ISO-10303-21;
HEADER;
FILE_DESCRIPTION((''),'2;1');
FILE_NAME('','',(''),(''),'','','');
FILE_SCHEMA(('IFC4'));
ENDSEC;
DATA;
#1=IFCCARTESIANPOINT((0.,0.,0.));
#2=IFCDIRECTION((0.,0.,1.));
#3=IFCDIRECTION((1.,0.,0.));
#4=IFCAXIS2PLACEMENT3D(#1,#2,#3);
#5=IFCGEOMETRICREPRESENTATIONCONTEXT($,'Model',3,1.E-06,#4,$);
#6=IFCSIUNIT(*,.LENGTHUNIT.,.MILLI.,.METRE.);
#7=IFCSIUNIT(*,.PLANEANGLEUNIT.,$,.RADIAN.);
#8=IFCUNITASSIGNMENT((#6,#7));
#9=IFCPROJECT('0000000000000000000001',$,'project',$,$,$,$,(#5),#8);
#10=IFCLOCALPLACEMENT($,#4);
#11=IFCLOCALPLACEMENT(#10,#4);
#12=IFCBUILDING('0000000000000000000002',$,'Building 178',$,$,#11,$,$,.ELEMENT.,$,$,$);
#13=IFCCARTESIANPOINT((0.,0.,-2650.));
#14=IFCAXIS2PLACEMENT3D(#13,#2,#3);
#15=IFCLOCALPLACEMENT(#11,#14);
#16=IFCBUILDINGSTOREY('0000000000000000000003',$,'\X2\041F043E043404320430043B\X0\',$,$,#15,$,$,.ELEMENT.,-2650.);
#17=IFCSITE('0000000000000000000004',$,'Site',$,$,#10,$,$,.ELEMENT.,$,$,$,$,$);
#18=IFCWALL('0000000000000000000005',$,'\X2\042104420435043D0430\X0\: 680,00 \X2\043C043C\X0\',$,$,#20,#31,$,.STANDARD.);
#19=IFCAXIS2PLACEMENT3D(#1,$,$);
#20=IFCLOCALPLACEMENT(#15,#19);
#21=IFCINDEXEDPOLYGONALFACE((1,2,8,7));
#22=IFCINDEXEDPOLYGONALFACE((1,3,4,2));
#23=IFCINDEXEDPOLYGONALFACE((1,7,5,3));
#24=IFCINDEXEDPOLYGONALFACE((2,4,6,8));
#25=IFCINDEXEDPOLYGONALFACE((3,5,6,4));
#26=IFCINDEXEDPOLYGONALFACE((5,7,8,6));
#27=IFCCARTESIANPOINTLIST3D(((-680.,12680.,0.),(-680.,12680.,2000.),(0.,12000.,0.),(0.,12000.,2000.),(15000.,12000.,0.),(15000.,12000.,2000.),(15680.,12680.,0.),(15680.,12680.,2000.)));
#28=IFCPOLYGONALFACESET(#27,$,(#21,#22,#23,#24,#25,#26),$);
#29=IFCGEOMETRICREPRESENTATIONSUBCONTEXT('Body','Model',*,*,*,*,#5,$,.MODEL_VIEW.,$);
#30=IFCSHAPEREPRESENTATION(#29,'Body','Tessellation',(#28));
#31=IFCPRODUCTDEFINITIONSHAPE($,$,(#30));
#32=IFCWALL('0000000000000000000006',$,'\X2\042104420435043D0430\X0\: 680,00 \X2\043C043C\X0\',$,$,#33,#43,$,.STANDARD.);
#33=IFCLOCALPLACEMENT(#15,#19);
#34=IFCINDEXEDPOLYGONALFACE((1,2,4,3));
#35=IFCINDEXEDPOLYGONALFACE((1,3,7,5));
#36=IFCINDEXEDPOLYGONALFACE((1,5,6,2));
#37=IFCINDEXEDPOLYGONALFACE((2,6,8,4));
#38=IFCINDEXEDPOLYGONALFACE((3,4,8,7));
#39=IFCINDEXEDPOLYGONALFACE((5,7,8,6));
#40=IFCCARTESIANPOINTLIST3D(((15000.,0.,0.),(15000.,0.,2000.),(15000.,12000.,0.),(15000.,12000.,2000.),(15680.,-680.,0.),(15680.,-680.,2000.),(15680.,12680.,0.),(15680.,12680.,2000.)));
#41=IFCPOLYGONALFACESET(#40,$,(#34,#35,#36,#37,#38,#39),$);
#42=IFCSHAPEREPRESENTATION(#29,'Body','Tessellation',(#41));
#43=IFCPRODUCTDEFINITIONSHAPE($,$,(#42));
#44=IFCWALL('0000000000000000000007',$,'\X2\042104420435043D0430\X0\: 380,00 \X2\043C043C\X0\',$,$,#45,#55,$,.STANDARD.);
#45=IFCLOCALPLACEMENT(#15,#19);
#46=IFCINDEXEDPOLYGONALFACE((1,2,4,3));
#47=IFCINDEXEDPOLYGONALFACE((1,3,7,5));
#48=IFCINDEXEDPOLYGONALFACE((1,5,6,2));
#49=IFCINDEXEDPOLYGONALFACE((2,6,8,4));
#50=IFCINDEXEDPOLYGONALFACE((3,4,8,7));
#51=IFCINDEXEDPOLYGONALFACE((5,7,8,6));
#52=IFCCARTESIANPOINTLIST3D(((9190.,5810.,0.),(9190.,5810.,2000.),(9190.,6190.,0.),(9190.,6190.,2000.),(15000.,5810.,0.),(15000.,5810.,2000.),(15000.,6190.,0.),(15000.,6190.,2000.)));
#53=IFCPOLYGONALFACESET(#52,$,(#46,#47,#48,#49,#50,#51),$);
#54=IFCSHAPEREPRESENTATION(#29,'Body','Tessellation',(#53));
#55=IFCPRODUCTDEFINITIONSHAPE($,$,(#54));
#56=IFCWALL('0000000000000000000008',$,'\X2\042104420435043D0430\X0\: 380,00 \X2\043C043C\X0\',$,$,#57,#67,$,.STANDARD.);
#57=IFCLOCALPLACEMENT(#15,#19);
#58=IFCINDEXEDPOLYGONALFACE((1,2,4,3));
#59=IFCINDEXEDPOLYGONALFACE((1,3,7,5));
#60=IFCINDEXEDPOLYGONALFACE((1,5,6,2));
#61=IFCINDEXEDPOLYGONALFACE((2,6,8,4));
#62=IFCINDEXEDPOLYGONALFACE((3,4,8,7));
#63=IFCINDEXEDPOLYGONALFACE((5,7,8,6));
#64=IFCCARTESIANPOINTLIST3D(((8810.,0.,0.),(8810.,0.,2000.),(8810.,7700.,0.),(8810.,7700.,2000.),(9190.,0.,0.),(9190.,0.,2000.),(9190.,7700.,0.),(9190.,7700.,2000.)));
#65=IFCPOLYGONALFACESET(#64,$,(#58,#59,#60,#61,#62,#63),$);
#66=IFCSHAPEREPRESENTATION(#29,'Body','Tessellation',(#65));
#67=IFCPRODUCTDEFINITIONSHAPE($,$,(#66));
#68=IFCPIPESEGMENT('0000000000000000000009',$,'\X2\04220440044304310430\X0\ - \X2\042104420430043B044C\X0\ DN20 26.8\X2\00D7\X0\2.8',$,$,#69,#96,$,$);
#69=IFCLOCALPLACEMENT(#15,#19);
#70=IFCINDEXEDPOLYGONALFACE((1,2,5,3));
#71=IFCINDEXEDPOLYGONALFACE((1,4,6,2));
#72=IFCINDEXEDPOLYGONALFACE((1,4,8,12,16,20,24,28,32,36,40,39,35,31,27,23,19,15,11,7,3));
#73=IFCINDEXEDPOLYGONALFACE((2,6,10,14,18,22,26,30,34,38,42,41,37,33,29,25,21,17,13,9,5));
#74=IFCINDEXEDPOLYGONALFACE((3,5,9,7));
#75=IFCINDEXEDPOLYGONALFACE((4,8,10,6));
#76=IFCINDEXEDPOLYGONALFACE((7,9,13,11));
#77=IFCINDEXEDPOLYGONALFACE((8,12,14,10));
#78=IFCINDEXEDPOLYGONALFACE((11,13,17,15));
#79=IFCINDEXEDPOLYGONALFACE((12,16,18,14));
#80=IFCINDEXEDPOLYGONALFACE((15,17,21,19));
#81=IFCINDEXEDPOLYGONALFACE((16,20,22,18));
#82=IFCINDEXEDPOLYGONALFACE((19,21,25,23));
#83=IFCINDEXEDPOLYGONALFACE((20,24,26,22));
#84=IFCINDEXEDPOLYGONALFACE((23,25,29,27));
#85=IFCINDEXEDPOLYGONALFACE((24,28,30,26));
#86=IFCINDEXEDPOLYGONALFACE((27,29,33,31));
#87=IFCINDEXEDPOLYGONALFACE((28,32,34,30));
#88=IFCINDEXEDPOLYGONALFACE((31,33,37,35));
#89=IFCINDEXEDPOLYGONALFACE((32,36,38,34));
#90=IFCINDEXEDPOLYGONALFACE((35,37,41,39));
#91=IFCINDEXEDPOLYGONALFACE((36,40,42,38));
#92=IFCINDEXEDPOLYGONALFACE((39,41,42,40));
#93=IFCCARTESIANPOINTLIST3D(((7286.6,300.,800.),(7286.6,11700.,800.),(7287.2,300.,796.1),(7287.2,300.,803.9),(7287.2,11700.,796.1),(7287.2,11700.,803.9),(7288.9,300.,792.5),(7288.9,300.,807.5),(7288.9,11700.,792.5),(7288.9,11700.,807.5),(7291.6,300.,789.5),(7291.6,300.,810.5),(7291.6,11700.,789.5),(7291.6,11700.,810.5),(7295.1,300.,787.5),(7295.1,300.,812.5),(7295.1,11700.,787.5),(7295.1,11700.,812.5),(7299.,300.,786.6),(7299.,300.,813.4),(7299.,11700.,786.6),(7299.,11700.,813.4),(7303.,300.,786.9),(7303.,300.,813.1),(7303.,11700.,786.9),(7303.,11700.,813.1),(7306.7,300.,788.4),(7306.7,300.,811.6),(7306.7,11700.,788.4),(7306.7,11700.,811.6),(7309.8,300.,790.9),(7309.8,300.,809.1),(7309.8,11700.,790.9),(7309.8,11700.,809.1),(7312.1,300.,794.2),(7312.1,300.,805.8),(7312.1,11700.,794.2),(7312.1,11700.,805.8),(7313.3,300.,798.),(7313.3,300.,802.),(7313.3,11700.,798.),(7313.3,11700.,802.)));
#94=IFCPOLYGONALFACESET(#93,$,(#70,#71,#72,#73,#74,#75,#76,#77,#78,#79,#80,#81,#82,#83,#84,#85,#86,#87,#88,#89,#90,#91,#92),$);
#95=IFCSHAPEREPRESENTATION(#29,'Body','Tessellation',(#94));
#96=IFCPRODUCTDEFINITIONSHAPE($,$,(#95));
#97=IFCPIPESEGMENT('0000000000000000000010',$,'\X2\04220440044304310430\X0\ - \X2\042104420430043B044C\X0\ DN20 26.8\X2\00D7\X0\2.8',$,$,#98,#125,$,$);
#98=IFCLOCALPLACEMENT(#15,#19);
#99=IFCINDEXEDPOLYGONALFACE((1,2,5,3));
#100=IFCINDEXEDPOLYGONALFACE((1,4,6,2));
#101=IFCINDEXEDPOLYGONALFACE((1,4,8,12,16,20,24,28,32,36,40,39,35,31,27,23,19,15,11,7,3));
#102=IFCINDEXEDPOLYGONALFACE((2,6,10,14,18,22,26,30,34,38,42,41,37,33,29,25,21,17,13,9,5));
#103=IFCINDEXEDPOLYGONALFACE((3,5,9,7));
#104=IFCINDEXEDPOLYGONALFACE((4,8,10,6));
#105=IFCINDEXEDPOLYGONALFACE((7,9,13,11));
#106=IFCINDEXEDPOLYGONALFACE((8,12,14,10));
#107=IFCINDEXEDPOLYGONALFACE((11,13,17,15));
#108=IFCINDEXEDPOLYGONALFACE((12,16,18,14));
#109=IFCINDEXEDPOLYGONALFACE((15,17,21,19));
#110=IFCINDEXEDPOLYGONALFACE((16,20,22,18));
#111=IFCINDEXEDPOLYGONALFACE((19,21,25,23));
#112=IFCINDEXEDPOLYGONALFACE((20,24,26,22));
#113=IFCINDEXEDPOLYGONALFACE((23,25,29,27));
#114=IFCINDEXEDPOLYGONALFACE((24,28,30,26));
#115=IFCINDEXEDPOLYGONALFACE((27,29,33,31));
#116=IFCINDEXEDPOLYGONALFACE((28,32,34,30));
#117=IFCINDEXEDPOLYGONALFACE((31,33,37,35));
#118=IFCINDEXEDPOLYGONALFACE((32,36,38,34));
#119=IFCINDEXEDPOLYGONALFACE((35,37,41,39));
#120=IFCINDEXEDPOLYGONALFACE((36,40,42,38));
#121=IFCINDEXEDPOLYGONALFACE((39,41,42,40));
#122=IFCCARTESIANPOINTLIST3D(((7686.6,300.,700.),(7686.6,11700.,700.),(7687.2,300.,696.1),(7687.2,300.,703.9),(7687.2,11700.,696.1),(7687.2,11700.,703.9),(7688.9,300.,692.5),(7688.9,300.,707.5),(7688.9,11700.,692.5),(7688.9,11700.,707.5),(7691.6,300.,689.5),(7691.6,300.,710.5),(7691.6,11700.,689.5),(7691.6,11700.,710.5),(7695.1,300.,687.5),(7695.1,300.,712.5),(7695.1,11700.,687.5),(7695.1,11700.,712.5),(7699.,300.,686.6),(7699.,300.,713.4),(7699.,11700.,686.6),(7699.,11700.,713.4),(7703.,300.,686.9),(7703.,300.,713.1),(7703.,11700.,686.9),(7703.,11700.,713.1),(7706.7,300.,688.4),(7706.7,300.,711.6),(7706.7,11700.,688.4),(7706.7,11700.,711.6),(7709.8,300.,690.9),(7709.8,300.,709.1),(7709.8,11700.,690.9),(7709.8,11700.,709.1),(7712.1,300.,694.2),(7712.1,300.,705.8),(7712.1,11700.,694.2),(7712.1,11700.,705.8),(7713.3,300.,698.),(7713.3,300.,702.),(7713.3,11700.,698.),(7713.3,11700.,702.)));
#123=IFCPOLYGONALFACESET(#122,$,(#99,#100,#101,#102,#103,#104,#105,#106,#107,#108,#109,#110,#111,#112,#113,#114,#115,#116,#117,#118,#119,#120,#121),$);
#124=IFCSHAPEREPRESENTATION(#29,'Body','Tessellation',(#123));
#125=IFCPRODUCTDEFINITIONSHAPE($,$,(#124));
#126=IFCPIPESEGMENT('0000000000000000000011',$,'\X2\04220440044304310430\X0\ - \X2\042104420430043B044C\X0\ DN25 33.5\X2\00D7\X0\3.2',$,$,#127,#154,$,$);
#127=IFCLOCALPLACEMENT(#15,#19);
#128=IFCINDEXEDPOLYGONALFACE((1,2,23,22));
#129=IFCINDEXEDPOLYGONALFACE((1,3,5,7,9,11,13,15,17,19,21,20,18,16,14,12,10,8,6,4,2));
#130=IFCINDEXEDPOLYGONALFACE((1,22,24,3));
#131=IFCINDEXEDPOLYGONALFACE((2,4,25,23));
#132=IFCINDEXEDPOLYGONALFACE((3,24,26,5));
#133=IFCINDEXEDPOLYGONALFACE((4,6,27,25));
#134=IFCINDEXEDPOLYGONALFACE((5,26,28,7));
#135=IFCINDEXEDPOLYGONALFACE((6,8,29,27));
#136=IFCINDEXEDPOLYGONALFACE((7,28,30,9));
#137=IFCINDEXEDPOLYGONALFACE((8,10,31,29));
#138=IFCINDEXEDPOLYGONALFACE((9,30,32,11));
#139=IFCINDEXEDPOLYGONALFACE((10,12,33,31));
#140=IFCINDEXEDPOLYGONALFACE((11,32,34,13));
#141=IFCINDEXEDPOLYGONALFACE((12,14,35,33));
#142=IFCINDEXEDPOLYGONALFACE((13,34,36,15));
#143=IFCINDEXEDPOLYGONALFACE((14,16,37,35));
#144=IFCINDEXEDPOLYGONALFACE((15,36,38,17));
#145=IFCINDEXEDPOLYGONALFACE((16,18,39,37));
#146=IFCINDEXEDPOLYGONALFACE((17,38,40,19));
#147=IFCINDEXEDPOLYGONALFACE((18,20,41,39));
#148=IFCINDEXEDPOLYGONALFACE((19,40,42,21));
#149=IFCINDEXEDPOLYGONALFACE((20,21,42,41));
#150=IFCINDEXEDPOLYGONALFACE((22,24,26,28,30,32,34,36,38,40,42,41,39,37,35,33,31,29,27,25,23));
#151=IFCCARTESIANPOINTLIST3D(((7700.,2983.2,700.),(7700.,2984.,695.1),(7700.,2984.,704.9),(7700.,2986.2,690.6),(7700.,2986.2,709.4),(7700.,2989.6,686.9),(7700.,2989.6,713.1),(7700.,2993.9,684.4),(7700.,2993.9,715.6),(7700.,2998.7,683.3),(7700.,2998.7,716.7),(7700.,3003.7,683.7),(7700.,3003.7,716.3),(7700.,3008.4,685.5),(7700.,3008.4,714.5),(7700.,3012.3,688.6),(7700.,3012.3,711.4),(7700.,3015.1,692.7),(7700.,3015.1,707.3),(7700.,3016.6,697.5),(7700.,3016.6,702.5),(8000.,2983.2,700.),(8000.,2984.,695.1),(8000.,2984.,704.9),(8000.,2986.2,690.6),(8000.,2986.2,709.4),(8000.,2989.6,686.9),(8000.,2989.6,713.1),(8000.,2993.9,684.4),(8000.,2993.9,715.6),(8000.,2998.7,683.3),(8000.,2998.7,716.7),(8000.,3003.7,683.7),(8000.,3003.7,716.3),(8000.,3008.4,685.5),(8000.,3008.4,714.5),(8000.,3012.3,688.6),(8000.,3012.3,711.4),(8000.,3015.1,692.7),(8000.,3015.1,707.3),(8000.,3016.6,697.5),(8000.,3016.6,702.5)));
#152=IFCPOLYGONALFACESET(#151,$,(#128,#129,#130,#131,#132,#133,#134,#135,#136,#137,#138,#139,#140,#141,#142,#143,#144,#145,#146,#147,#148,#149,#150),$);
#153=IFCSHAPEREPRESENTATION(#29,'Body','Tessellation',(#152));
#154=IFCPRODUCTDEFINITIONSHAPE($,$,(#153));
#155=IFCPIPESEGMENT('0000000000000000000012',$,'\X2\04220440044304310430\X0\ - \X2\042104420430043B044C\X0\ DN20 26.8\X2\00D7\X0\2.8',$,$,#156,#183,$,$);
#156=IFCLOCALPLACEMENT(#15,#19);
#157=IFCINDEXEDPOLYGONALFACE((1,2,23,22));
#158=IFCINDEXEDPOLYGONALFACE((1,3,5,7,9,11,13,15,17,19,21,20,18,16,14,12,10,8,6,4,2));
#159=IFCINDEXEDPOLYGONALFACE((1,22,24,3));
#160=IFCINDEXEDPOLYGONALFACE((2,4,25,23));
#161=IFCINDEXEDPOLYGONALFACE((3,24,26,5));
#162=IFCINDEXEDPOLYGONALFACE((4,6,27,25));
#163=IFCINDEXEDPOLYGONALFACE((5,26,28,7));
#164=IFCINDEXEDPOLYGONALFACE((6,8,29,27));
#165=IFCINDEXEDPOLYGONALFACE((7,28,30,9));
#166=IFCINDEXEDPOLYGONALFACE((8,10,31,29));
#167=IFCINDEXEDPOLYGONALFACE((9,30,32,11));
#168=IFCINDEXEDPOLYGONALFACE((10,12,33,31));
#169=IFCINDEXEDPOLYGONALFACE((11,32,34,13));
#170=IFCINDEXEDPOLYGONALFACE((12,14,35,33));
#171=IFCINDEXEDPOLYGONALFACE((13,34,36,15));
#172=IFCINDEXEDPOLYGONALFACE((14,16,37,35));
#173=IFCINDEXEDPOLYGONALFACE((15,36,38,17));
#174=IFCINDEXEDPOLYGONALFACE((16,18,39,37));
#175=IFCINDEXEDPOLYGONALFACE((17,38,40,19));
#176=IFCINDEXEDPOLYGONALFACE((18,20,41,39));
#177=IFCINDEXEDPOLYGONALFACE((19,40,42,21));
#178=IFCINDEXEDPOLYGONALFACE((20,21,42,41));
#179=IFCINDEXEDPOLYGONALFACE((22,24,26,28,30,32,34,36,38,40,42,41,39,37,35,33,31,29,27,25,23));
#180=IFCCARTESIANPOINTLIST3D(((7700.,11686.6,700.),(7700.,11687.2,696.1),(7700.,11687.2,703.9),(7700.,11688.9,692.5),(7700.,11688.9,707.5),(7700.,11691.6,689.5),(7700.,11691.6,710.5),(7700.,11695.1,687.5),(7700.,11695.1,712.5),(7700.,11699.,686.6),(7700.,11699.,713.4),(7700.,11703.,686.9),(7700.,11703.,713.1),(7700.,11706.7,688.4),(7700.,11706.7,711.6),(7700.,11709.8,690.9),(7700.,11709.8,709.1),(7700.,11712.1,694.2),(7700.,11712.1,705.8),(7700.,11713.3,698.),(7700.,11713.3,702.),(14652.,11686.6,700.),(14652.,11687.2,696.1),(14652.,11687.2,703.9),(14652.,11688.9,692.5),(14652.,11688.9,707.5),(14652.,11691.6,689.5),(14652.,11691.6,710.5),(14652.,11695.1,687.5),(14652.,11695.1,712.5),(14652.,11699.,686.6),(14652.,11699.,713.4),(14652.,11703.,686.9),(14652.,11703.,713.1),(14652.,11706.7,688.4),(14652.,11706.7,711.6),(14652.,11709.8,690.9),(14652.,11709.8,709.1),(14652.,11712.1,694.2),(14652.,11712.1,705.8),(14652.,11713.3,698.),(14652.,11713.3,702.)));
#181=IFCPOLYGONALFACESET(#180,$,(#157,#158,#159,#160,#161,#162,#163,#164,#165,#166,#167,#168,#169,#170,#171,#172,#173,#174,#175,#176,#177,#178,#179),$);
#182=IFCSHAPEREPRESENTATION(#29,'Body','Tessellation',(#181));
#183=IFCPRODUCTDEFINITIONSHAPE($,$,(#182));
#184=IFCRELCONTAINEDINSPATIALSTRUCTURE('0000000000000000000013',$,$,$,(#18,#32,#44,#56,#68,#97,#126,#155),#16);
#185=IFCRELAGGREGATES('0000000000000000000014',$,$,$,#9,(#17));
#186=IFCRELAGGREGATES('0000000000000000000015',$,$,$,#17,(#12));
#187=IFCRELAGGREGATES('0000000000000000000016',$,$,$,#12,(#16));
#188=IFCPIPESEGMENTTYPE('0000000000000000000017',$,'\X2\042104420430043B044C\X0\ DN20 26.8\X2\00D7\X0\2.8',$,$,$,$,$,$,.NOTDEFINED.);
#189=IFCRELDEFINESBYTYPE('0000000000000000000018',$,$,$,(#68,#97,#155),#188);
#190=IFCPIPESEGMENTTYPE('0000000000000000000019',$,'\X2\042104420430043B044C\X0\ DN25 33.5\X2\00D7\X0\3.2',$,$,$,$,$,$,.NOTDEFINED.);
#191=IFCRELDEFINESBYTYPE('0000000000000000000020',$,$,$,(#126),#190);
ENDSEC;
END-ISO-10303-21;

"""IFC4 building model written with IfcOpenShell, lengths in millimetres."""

from ifc_helpers import new_model, entity, si_unit, frame, origin_with_axes, place, context, subcontext, project, spatial, line, indexed_curve, outline, extrude, source, transform, mapped, type_object, element, save


model = new_model("IFC4")

# Units and contexts
model_context = context("Model", 3, precision=1e-06, world=origin_with_axes())
body_context = subcontext(model_context, "Body", "Model", "MODEL_VIEW")
ifc_project = project(units=[si_unit("LENGTHUNIT", "METRE", prefix="MILLI"), si_unit("PLANEANGLEUNIT", "RADIAN")], contexts=[model_context])

# Site, building, storey
site_placement = place(None, origin_with_axes())
site = spatial("IfcSite", under=ifc_project, at=site_placement, Name="Site", CompositionType="ELEMENT")
building_placement = place(site_placement, origin_with_axes())
building = spatial("IfcBuilding", under=site, at=building_placement, Name="Building 178", CompositionType="ELEMENT")
storey_placement = place(building_placement, frame((0.0, 0.0, -2650.0), z_axis=(0.0, 0.0, 1.0), x_axis=(1.0, 0.0, 0.0)))
storey = spatial("IfcBuildingStorey", under=building, at=storey_placement, Name="Подвал", CompositionType="ELEMENT", Elevation=-2650.0)

# Walls
shared_shape_1 = source(origin_with_axes(), body_context, "Body", "SweptSolid", [
    extrude(outline(indexed_curve([(-340.0, -340.0), (16020.0, -340.0), (15340.0, 340.0), (340.0, 340.0)], segments=[line(1, 2), line(2, 3), line(3, 4), line(4, 1)])), origin_with_axes(), (0.0, 0.0, 1.0), 2000.0),
])
wall_1_placement = place(storey_placement, frame((15340.0, 12340.0, 0.0), z_axis=(0.0, 0.0, 1.0), x_axis=(-1.0, 0.0, 0.0)))
element("IfcWall", 1, at=wall_1_placement, inside=storey, Name="Стена: 680,00 мм", PredefinedType="STANDARD", context=body_context, shape_type="MappedRepresentation", body=[
    mapped(shared_shape_1, transform((0.0, 0.0, 0.0), x_axis=(1.0, 0.0, 0.0), y_axis=(0.0, 1.0, 0.0), z_axis=(0.0, 0.0, 1.0), scale=1.0)),
])
shared_shape_2 = source(origin_with_axes(), body_context, "Body", "SweptSolid", [
    extrude(outline(indexed_curve([(-340.0, -340.0), (13020.0, -340.0), (12340.0, 340.0), (340.0, 340.0)], segments=[line(1, 2), line(2, 3), line(3, 4), line(4, 1)])), origin_with_axes(), (0.0, 0.0, 1.0), 2000.0),
])
wall_2_placement = place(storey_placement, frame((15340.0, -340.0, 0.0), z_axis=(0.0, 0.0, 1.0), x_axis=(0.0, 1.0, 0.0)))
element("IfcWall", 2, at=wall_2_placement, inside=storey, Name="Стена: 680,00 мм", PredefinedType="STANDARD", context=body_context, shape_type="MappedRepresentation", body=[
    mapped(shared_shape_2, transform((0.0, 0.0, 0.0), x_axis=(1.0, 0.0, 0.0), y_axis=(0.0, 1.0, 0.0), z_axis=(0.0, 0.0, 1.0), scale=1.0)),
])
shared_shape_3 = source(origin_with_axes(), body_context, "Body", "SweptSolid", [
    extrude(outline(indexed_curve([(190.0, -190.0), (6000.0, -190.0), (6000.0, 190.0), (190.0, 190.0)], segments=[line(1, 2), line(2, 3), line(3, 4), line(4, 1)])), origin_with_axes(), (0.0, 0.0, 1.0), 2000.0),
])
wall_3_placement = place(storey_placement, frame((9000.0, 6000.0, 0.0), z_axis=(0.0, 0.0, 1.0), x_axis=(1.0, 0.0, 0.0)))
element("IfcWall", 3, at=wall_3_placement, inside=storey, Name="Стена: 380,00 мм", PredefinedType="STANDARD", context=body_context, shape_type="MappedRepresentation", body=[
    mapped(shared_shape_3, transform((0.0, 0.0, 0.0), x_axis=(1.0, 0.0, 0.0), y_axis=(0.0, 1.0, 0.0), z_axis=(0.0, 0.0, 1.0), scale=1.0)),
])
shared_shape_4 = source(origin_with_axes(), body_context, "Body", "SweptSolid", [
    extrude(outline(indexed_curve([(0.0, -190.0), (7700.0, -190.0), (7700.0, 190.0), (0.0, 190.0)], segments=[line(1, 2), line(2, 3), line(3, 4), line(4, 1)])), origin_with_axes(), (0.0, 0.0, 1.0), 2000.0),
])
wall_4_placement = place(storey_placement, frame((9000.0, 0.0, 0.0), z_axis=(0.0, 0.0, 1.0), x_axis=(0.0, 1.0, 0.0)))
element("IfcWall", 4, at=wall_4_placement, inside=storey, Name="Стена: 380,00 мм", PredefinedType="STANDARD", context=body_context, shape_type="MappedRepresentation", body=[
    mapped(shared_shape_4, transform((0.0, 0.0, 0.0), x_axis=(1.0, 0.0, 0.0), y_axis=(0.0, 1.0, 0.0), z_axis=(0.0, 0.0, 1.0), scale=1.0)),
])

# Pipe segments
pipe_segment_type_1 = type_object("IfcPipeSegmentType", Name="Сталь DN20 26.8×2.8", PredefinedType="NOTDEFINED")
shared_shape_5 = source(origin_with_axes(), body_context, "Body", "AdvancedSweptSolid", [
    entity("IfcSweptDiskSolid", entity("IfcIndexedPolyCurve", entity("IfcCartesianPointList3D", [[0.0, 0.0, 0.0], [0.0, 0.0, -11400.0]]), [entity("IfcLineIndex", [1, 2])]), 13.4),
])
for number, where, z_axis, x_axis, name in (
    (5, (7300.0, 300.0, 800.0), (0.0, -1.0, 0.0), (1.0, 0.0, 0.0), "Труба - Сталь DN20 26.8×2.8"),
    (6, (7700.0, 300.0, 700.0), (0.0, -1.0, 0.0), (1.0, 0.0, 0.0), "Труба - Сталь DN20 26.8×2.8"),
):
    element("IfcPipeSegment", number, at=place(storey_placement, frame(where, z_axis=z_axis, x_axis=x_axis)), inside=storey, type_object=pipe_segment_type_1, Name=name, context=body_context, shape_type="MappedRepresentation", body=[
        mapped(shared_shape_5, transform((0.0, 0.0, 0.0), x_axis=(1.0, 0.0, 0.0), y_axis=(0.0, 1.0, 0.0), z_axis=(0.0, 0.0, 1.0), scale=1.0)),
    ])
pipe_segment_type_2 = type_object("IfcPipeSegmentType", Name="Сталь DN25 33.5×3.2", PredefinedType="NOTDEFINED")
shared_shape_6 = source(origin_with_axes(), body_context, "Body", "AdvancedSweptSolid", [
    entity("IfcSweptDiskSolid", entity("IfcIndexedPolyCurve", entity("IfcCartesianPointList3D", [[0.0, 0.0, 0.0], [0.0, 0.0, -300.0]]), [entity("IfcLineIndex", [1, 2])]), 16.8),
])
pipe_segment_1_placement = place(storey_placement, frame((8000.0, 3000.0, 700.0), z_axis=(1.0, 0.0, 0.0), x_axis=(0.0, 1.0, 0.0)))
element("IfcPipeSegment", 7, at=pipe_segment_1_placement, inside=storey, type_object=pipe_segment_type_2, Name="Труба - Сталь DN25 33.5×3.2", context=body_context, shape_type="MappedRepresentation", body=[
    mapped(shared_shape_6, transform((0.0, 0.0, 0.0), x_axis=(1.0, 0.0, 0.0), y_axis=(0.0, 1.0, 0.0), z_axis=(0.0, 0.0, 1.0), scale=1.0)),
])
shared_shape_7 = source(origin_with_axes(), body_context, "Body", "AdvancedSweptSolid", [
    entity("IfcSweptDiskSolid", entity("IfcIndexedPolyCurve", entity("IfcCartesianPointList3D", [[0.0, 0.0, 0.0], [0.0, 0.0, -6952.0]]), [entity("IfcLineIndex", [1, 2])]), 13.4),
])
for number, where, z_axis, x_axis, name in (
    (8, (14652.0, 11700.0, 700.0), (1.0, 0.0, 0.0), (0.0, 1.0, 0.0), "Труба - Сталь DN20 26.8×2.8"),
):
    element("IfcPipeSegment", number, at=place(storey_placement, frame(where, z_axis=z_axis, x_axis=x_axis)), inside=storey, type_object=pipe_segment_type_1, Name=name, context=body_context, shape_type="MappedRepresentation", body=[
        mapped(shared_shape_7, transform((0.0, 0.0, 0.0), x_axis=(1.0, 0.0, 0.0), y_axis=(0.0, 1.0, 0.0), z_axis=(0.0, 0.0, 1.0), scale=1.0)),
    ])

save(model, "model.ifc")
